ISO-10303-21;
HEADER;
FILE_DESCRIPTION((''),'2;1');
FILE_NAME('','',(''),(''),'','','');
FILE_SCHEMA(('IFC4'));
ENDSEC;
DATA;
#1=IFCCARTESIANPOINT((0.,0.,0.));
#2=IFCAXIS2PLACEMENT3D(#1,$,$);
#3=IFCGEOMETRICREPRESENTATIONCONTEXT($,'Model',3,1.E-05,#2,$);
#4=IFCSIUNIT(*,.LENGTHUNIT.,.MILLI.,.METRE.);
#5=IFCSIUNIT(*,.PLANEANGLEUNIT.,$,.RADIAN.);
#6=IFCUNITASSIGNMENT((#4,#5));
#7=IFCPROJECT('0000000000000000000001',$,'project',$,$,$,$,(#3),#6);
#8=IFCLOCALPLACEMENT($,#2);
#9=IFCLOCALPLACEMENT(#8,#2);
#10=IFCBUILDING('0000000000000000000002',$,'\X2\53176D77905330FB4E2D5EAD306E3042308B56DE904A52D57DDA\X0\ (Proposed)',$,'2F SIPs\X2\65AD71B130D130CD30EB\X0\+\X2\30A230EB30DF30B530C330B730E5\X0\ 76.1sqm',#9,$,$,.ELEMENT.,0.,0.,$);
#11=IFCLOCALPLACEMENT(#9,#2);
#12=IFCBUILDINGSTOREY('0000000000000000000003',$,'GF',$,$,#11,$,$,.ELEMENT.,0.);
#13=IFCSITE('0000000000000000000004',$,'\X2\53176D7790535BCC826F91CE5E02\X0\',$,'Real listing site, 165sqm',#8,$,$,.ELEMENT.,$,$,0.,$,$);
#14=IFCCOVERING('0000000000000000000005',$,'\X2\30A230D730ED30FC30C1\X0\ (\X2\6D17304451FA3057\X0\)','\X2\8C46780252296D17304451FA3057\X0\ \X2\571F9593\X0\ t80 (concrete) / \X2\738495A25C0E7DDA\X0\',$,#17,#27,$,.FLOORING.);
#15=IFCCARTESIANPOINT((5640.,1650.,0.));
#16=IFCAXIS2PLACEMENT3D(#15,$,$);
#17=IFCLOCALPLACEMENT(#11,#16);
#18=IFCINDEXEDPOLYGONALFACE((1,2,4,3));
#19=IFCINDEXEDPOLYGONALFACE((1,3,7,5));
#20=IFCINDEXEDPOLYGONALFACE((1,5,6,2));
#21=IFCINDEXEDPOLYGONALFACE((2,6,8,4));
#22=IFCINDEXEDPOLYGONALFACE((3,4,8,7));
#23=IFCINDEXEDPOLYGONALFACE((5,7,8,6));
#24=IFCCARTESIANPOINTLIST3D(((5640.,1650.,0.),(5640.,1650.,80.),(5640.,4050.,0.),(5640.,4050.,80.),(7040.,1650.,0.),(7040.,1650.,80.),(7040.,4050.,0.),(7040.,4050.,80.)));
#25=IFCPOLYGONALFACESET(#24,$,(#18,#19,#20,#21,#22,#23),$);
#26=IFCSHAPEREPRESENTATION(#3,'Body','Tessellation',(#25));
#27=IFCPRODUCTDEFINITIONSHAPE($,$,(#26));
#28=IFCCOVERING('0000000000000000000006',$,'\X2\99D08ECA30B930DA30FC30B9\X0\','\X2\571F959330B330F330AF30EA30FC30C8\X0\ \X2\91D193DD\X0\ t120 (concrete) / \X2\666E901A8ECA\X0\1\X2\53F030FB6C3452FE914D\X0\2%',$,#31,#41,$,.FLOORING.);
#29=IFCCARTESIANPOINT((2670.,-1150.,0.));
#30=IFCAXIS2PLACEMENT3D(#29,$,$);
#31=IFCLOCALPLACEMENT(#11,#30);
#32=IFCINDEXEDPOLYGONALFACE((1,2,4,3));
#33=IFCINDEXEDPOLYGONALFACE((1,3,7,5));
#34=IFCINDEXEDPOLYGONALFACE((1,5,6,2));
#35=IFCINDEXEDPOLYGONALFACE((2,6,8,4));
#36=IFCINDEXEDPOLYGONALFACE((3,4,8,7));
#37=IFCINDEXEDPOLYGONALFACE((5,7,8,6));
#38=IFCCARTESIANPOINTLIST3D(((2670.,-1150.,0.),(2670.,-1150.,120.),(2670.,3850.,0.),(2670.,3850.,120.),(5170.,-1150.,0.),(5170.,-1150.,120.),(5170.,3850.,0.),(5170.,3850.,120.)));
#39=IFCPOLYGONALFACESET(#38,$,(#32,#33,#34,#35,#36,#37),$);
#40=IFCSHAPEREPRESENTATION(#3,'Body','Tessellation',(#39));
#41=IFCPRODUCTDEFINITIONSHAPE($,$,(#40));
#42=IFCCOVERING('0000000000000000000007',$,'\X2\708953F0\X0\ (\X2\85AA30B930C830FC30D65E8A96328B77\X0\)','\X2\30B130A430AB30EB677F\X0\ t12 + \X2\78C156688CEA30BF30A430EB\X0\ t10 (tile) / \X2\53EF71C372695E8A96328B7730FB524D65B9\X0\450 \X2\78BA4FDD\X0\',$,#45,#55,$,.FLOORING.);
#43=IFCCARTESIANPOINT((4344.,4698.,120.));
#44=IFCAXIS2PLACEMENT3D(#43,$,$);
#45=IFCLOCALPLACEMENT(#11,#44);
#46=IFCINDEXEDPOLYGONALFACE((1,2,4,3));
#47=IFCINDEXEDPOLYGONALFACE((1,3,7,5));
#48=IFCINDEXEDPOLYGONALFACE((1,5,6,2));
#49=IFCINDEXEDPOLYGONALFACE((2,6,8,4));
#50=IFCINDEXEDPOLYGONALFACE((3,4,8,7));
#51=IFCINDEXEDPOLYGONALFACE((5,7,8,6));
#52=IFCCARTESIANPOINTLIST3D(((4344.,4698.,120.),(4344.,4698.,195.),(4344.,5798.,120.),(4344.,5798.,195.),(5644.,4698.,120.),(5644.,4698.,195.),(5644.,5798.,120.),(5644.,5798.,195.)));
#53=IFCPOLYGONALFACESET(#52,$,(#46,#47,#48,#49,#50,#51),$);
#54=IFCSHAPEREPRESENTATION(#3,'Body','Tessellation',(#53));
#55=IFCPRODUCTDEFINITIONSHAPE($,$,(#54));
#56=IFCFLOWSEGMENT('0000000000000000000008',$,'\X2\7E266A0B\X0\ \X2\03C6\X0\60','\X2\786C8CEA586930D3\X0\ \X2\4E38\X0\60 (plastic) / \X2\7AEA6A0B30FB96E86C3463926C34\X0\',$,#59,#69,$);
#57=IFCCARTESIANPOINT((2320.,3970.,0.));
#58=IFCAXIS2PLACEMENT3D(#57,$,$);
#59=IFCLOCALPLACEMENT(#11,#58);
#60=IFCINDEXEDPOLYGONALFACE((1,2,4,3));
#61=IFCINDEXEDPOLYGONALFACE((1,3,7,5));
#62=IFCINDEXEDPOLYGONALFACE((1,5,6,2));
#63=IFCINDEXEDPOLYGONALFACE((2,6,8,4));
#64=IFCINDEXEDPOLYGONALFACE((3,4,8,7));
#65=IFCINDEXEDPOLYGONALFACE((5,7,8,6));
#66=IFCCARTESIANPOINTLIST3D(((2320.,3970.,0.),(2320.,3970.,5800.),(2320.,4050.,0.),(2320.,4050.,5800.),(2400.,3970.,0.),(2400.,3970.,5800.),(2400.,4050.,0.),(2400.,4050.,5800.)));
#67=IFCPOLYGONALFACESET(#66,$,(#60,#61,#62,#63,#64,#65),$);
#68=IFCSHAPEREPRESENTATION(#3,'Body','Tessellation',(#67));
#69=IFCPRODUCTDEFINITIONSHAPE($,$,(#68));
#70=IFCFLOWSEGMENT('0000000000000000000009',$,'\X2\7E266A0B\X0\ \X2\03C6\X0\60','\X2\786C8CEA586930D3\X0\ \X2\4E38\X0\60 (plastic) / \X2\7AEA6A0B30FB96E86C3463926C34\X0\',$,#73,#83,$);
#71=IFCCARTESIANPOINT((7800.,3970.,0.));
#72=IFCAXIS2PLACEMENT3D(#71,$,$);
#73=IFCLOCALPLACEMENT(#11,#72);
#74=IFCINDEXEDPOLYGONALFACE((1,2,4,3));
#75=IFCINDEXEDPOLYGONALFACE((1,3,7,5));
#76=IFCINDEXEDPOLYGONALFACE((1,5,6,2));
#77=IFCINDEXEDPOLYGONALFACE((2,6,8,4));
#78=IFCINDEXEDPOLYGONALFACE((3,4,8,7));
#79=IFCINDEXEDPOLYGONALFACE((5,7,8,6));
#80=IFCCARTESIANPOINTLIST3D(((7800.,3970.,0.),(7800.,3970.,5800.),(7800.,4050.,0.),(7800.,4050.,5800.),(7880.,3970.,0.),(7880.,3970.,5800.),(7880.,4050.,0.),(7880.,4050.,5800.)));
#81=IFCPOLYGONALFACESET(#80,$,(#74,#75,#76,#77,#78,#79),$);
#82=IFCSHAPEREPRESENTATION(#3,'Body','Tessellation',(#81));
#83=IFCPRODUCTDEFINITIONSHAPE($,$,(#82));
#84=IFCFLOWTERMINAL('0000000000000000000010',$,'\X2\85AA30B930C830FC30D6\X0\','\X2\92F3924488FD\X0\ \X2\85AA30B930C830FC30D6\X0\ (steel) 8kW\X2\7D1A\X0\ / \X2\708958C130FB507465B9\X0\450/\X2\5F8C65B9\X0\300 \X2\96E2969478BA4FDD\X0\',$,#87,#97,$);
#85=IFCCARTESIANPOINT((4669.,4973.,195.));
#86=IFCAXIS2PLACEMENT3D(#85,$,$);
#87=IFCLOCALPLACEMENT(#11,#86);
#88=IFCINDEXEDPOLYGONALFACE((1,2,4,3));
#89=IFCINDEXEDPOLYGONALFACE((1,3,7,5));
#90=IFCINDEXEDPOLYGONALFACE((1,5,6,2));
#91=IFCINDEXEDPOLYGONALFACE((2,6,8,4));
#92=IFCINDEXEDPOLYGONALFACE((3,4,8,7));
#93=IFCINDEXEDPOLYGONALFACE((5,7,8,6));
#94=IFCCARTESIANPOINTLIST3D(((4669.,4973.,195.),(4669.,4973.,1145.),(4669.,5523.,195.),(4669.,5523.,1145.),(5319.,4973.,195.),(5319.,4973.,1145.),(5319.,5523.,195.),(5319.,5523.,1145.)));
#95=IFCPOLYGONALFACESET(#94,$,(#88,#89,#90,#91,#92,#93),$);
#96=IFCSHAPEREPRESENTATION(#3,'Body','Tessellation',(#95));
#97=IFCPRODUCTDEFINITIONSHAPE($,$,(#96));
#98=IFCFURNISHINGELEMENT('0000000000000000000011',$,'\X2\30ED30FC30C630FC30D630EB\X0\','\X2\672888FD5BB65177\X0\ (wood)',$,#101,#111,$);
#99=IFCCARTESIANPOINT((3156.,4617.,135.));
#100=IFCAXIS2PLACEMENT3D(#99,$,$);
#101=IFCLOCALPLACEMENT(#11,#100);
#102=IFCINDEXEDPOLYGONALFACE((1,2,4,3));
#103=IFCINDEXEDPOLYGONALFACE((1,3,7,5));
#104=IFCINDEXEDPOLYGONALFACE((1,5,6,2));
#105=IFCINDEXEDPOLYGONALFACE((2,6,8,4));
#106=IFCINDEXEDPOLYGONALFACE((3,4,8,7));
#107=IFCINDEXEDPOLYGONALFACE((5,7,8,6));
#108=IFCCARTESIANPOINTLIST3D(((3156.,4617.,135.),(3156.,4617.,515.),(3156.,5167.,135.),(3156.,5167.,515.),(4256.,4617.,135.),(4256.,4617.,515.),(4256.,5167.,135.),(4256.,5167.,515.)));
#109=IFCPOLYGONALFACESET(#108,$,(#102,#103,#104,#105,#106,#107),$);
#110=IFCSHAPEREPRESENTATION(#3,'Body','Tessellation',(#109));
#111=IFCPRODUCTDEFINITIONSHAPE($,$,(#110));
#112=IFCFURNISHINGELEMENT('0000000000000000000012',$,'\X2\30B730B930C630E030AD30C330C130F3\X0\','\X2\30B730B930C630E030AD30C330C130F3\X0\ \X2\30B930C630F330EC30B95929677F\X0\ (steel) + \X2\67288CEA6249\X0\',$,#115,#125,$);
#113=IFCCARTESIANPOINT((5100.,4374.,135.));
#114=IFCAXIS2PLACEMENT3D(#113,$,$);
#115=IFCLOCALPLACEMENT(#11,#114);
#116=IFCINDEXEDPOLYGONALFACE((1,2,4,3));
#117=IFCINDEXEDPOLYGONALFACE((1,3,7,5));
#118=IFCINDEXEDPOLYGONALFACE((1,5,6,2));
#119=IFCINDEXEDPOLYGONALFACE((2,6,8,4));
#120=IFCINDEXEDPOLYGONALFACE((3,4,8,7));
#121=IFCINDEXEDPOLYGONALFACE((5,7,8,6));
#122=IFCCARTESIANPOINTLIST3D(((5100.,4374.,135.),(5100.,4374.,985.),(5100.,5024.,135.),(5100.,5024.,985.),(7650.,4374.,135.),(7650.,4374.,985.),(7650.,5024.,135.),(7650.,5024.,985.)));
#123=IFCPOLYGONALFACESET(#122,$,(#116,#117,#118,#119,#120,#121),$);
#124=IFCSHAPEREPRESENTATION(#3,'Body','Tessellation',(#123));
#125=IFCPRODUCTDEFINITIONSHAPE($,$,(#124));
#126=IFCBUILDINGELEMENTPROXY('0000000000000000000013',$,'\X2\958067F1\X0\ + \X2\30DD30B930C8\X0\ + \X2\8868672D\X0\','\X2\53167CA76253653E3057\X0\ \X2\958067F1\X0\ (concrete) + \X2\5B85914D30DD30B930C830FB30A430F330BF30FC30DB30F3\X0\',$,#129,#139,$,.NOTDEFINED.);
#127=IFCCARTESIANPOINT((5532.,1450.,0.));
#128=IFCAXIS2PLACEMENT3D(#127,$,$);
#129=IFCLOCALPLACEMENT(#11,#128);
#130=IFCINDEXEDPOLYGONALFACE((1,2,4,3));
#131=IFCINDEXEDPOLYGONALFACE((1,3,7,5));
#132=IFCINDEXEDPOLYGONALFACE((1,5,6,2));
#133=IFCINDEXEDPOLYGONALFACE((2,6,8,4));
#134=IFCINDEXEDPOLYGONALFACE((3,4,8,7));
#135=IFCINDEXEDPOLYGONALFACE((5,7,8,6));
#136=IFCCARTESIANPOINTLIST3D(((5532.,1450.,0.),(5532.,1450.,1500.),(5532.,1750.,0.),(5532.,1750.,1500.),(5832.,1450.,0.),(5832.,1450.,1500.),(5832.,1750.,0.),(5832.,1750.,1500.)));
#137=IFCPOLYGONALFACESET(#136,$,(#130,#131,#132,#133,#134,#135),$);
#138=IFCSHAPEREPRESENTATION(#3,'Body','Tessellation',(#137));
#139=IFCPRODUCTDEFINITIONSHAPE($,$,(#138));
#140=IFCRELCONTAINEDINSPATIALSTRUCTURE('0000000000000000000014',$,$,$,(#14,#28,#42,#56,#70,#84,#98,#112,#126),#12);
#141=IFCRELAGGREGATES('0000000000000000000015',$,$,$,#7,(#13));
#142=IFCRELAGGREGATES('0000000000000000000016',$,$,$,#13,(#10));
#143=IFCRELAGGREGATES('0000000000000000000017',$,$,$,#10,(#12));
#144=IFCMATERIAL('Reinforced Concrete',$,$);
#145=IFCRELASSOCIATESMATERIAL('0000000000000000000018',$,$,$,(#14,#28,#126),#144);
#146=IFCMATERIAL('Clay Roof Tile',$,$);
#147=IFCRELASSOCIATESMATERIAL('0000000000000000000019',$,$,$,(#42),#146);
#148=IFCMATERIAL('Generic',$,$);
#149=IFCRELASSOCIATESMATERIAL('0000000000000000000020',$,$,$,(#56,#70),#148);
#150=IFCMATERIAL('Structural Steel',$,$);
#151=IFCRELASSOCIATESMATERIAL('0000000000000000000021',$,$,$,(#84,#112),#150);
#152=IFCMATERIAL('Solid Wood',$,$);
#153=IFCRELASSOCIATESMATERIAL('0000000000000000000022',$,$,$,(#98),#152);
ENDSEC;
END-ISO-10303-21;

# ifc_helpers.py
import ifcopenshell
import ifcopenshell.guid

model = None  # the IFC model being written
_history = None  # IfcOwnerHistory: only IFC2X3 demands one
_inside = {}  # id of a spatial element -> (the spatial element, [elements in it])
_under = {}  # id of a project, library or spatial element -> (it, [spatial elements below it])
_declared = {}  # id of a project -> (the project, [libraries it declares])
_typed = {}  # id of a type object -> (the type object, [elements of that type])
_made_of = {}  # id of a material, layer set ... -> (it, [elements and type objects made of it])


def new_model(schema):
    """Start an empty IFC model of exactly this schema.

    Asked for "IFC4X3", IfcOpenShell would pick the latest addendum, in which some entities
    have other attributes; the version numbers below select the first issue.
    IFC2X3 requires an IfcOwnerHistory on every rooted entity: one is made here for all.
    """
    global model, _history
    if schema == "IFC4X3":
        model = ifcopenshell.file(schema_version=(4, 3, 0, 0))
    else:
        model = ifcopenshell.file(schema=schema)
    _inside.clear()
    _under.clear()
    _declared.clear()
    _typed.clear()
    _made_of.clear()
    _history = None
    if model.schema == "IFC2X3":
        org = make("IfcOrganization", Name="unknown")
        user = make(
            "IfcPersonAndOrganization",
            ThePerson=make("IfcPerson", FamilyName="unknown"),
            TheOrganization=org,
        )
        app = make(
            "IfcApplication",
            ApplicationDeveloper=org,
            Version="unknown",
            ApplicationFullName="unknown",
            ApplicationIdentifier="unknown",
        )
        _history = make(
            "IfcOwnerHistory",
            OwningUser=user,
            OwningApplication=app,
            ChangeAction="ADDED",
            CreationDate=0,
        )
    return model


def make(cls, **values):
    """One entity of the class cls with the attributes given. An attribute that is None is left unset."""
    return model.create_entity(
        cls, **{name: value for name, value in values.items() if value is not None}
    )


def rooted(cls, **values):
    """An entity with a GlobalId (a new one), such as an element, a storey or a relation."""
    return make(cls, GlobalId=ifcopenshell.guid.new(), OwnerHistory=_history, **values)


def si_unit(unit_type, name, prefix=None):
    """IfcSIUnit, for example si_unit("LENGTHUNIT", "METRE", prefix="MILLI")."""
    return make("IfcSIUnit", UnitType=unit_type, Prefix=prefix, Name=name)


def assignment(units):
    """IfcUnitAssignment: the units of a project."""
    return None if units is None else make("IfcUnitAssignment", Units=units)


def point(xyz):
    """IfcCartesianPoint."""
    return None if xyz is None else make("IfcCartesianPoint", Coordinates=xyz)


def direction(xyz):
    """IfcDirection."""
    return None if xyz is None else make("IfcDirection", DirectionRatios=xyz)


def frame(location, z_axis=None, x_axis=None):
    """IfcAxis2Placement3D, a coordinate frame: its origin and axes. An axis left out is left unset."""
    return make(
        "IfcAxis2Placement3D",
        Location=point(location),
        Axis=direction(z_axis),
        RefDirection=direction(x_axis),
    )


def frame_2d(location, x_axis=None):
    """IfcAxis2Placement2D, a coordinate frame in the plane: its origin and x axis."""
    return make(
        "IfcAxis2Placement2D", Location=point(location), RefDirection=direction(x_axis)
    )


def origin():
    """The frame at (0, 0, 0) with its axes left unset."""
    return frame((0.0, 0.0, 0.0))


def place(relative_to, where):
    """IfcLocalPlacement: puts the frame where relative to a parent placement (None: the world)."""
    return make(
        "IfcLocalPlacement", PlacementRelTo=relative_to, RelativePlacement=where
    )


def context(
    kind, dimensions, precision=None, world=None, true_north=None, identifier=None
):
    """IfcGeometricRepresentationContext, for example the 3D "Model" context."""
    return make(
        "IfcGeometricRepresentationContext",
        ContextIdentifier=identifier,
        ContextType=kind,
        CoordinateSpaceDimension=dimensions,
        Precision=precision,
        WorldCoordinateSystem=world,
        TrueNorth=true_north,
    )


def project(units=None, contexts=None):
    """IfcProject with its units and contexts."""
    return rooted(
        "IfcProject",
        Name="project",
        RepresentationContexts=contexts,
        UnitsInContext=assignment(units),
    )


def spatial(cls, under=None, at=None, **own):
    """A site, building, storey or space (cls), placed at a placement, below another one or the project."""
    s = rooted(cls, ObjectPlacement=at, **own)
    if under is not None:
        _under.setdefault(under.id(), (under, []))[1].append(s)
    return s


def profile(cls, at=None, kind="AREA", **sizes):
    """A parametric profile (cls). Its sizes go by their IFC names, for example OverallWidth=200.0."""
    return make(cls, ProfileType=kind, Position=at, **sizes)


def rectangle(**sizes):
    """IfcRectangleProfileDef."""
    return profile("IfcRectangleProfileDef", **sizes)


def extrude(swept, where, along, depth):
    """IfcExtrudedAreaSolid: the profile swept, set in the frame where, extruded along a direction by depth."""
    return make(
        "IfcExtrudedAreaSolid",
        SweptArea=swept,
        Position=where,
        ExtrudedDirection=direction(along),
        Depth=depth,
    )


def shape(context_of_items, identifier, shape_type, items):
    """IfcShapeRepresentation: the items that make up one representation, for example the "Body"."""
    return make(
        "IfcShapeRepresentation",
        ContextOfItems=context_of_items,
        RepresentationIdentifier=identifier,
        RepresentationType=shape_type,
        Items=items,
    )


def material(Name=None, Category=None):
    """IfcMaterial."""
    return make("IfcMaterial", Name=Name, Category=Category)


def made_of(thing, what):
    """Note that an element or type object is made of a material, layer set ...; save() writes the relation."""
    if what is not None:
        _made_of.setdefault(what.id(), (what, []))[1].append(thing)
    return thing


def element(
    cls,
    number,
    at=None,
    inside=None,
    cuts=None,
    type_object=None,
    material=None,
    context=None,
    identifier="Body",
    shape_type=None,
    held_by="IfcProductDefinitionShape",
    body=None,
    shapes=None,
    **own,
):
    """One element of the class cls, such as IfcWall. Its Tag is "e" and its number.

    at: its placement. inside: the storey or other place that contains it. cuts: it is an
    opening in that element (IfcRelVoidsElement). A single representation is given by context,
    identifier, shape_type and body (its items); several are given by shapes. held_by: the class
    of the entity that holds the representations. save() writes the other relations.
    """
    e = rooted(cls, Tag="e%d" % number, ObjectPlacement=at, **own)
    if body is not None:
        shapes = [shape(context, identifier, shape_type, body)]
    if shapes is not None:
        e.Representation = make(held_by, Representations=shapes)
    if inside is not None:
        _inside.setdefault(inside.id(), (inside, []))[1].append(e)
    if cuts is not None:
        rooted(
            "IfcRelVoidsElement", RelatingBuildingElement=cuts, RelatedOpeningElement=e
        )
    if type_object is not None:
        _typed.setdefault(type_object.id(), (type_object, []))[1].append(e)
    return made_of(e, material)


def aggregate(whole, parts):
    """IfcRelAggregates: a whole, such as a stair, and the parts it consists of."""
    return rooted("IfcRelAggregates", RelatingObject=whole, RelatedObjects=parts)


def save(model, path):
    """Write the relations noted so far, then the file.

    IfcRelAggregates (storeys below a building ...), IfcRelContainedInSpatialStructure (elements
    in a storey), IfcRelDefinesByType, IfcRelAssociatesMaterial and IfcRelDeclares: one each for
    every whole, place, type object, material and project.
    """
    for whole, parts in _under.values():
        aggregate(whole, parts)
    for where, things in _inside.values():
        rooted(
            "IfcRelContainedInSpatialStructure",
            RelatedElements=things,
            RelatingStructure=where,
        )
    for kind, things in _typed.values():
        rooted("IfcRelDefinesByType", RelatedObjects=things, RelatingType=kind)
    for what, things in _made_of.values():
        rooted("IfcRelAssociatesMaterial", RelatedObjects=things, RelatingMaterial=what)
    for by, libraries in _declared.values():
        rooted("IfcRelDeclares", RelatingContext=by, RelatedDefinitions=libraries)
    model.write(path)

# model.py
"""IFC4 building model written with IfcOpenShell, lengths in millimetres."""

from ifc_helpers import new_model, si_unit, frame, frame_2d, origin, place, context, project, spatial, rectangle, extrude, material, element, save


model = new_model("IFC4")

# Units and contexts
model_context = context("Model", 3, precision=1e-05, world=origin())
ifc_project = project(units=[si_unit("LENGTHUNIT", "METRE", prefix="MILLI"), si_unit("PLANEANGLEUNIT", "RADIAN")], contexts=[model_context])

# Site, building, storey
site_placement = place(None, origin())
site = spatial("IfcSite", under=ifc_project, at=site_placement, Name="北海道富良野市", ObjectType="Real listing site, 165sqm", CompositionType="ELEMENT", RefElevation=0.0)
building_placement = place(site_placement, origin())
building = spatial("IfcBuilding", under=site, at=building_placement, Name="北海道・中庭のある回遊動線 (Proposed)", ObjectType="2F SIPs断熱パネル+アルミサッシュ 76.1sqm", CompositionType="ELEMENT", ElevationOfRefHeight=0.0, ElevationOfTerrain=0.0)
storey_placement = place(building_placement, origin())
storey = spatial("IfcBuildingStorey", under=building, at=storey_placement, Name="GF", CompositionType="ELEMENT", Elevation=0.0)

# Shared definitions
ifc_material_1 = material(Name="Solid Wood")

# Shared definitions
ifc_material_2 = material(Name="Reinforced Concrete")

# Coverings
ifc_material_3 = material(Name="Generic")
covering_1_placement = place(storey_placement, frame((5640.0, 1650.0, 0.0)))
element("IfcCovering", 1, at=covering_1_placement, inside=storey, material=ifc_material_2, Name="アプローチ (洗い出し)", Description="豆砂利洗い出し 土間 t80 (concrete) / 玄関導線", PredefinedType="FLOORING", context=model_context, shape_type="SweptSolid", body=[
    extrude(rectangle(XDim=1400.0, YDim=2400.0, at=frame_2d((700.0, 1200.0))), frame((5640.0, 1650.0, 0.0)), (0.0, 0.0, 1.0), 80.0),
])
covering_2_placement = place(storey_placement, frame((2670.0, -1150.0, 0.0)))
element("IfcCovering", 2, at=covering_2_placement, inside=storey, material=ifc_material_2, Name="駐車スペース", Description="土間コンクリート 金鏝 t120 (concrete) / 普通車1台・水勾配2%", PredefinedType="FLOORING", context=model_context, shape_type="SweptSolid", body=[
    extrude(rectangle(XDim=2500.0, YDim=5000.0, at=frame_2d((1250.0, 2500.0))), frame((2670.0, -1150.0, 0.0)), (0.0, 0.0, 1.0), 120.0),
])
ifc_material_4 = material(Name="Clay Roof Tile")
covering_3_placement = place(storey_placement, frame((4344.0, 4698.0, 120.0)))
element("IfcCovering", 3, at=covering_3_placement, inside=storey, material=ifc_material_4, Name="炉台 (薪ストーブ床防護)", Description="ケイカル板 t12 + 磁器質タイル t10 (tile) / 可燃物床防護・前方450 確保", PredefinedType="FLOORING", context=model_context, shape_type="SweptSolid", body=[
    extrude(rectangle(XDim=1300.0, YDim=1100.0, at=frame_2d((650.0, 550.0))), frame((4344.0, 4698.0, 120.0)), (0.0, 0.0, 1.0), 75.0),
])

# Flow segments
flow_segment_1_placement = place(storey_placement, frame((2320.0, 3970.0, 0.0)))
element("IfcFlowSegment", 4, at=flow_segment_1_placement, inside=storey, material=ifc_material_3, Name="縦樋 φ60", Description="硬質塩ビ 丸60 (plastic) / 竪樋・雨水排水", context=model_context, shape_type="SweptSolid", body=[
    extrude(rectangle(XDim=80.0, YDim=80.0, at=frame_2d((40.0, 40.0))), frame((2320.0, 3970.0, 0.0)), (0.0, 0.0, 1.0), 5800.0),
])
flow_segment_2_placement = place(storey_placement, frame((7800.0, 3970.0, 0.0)))
element("IfcFlowSegment", 5, at=flow_segment_2_placement, inside=storey, material=ifc_material_3, Name="縦樋 φ60", Description="硬質塩ビ 丸60 (plastic) / 竪樋・雨水排水", context=model_context, shape_type="SweptSolid", body=[
    extrude(rectangle(XDim=80.0, YDim=80.0, at=frame_2d((40.0, 40.0))), frame((7800.0, 3970.0, 0.0)), (0.0, 0.0, 1.0), 5800.0),
])

# Flow terminal
ifc_material_5 = material(Name="Structural Steel")
flow_terminal_placement = place(storey_placement, frame((4669.0, 4973.0, 195.0)))
element("IfcFlowTerminal", 6, at=flow_terminal_placement, inside=storey, material=ifc_material_5, Name="薪ストーブ", Description="鋳鉄製 薪ストーブ (steel) 8kW級 / 炉壁・側方450/後方300 離隔確保", context=model_context, shape_type="SweptSolid", body=[
    extrude(rectangle(XDim=650.0, YDim=550.0, at=frame_2d((325.0, 275.0))), frame((4669.0, 4973.0, 195.0)), (0.0, 0.0, 1.0), 950.0),
])

# Furnishing elements
furnishing_1_placement = place(storey_placement, frame((3156.0, 4617.0, 135.0)))
element("IfcFurnishingElement", 7, at=furnishing_1_placement, inside=storey, material=ifc_material_1, Name="ローテーブル", Description="木製家具 (wood)", context=model_context, shape_type="SweptSolid", body=[
    extrude(rectangle(XDim=1100.0, YDim=550.0, at=frame_2d((550.0, 275.0))), frame((3156.0, 4617.0, 135.0)), (0.0, 0.0, 1.0), 380.0),
])
furnishing_2_placement = place(storey_placement, frame((5100.0, 4374.0, 135.0)))
element("IfcFurnishingElement", 8, at=furnishing_2_placement, inside=storey, material=ifc_material_5, Name="システムキッチン", Description="システムキッチン ステンレス天板 (steel) + 木質扉", context=model_context, shape_type="SweptSolid", body=[
    extrude(rectangle(XDim=2550.0, YDim=650.0, at=frame_2d((1275.0, 325.0))), frame((5100.0, 4374.0, 135.0)), (0.0, 0.0, 1.0), 850.0),
])

# Building element proxy
proxy_placement = place(storey_placement, frame((5532.0, 1450.0, 0.0)))
element("IfcBuildingElementProxy", 9, at=proxy_placement, inside=storey, material=ifc_material_2, Name="門柱 + ポスト + 表札", Description="化粧打放し 門柱 (concrete) + 宅配ポスト・インターホン", PredefinedType="NOTDEFINED", context=model_context, shape_type="SweptSolid", body=[
    extrude(rectangle(XDim=300.0, YDim=300.0, at=frame_2d((150.0, 150.0))), frame((5532.0, 1450.0, 0.0)), (0.0, 0.0, 1.0), 1500.0),
])

save(model, "model.ifc")
